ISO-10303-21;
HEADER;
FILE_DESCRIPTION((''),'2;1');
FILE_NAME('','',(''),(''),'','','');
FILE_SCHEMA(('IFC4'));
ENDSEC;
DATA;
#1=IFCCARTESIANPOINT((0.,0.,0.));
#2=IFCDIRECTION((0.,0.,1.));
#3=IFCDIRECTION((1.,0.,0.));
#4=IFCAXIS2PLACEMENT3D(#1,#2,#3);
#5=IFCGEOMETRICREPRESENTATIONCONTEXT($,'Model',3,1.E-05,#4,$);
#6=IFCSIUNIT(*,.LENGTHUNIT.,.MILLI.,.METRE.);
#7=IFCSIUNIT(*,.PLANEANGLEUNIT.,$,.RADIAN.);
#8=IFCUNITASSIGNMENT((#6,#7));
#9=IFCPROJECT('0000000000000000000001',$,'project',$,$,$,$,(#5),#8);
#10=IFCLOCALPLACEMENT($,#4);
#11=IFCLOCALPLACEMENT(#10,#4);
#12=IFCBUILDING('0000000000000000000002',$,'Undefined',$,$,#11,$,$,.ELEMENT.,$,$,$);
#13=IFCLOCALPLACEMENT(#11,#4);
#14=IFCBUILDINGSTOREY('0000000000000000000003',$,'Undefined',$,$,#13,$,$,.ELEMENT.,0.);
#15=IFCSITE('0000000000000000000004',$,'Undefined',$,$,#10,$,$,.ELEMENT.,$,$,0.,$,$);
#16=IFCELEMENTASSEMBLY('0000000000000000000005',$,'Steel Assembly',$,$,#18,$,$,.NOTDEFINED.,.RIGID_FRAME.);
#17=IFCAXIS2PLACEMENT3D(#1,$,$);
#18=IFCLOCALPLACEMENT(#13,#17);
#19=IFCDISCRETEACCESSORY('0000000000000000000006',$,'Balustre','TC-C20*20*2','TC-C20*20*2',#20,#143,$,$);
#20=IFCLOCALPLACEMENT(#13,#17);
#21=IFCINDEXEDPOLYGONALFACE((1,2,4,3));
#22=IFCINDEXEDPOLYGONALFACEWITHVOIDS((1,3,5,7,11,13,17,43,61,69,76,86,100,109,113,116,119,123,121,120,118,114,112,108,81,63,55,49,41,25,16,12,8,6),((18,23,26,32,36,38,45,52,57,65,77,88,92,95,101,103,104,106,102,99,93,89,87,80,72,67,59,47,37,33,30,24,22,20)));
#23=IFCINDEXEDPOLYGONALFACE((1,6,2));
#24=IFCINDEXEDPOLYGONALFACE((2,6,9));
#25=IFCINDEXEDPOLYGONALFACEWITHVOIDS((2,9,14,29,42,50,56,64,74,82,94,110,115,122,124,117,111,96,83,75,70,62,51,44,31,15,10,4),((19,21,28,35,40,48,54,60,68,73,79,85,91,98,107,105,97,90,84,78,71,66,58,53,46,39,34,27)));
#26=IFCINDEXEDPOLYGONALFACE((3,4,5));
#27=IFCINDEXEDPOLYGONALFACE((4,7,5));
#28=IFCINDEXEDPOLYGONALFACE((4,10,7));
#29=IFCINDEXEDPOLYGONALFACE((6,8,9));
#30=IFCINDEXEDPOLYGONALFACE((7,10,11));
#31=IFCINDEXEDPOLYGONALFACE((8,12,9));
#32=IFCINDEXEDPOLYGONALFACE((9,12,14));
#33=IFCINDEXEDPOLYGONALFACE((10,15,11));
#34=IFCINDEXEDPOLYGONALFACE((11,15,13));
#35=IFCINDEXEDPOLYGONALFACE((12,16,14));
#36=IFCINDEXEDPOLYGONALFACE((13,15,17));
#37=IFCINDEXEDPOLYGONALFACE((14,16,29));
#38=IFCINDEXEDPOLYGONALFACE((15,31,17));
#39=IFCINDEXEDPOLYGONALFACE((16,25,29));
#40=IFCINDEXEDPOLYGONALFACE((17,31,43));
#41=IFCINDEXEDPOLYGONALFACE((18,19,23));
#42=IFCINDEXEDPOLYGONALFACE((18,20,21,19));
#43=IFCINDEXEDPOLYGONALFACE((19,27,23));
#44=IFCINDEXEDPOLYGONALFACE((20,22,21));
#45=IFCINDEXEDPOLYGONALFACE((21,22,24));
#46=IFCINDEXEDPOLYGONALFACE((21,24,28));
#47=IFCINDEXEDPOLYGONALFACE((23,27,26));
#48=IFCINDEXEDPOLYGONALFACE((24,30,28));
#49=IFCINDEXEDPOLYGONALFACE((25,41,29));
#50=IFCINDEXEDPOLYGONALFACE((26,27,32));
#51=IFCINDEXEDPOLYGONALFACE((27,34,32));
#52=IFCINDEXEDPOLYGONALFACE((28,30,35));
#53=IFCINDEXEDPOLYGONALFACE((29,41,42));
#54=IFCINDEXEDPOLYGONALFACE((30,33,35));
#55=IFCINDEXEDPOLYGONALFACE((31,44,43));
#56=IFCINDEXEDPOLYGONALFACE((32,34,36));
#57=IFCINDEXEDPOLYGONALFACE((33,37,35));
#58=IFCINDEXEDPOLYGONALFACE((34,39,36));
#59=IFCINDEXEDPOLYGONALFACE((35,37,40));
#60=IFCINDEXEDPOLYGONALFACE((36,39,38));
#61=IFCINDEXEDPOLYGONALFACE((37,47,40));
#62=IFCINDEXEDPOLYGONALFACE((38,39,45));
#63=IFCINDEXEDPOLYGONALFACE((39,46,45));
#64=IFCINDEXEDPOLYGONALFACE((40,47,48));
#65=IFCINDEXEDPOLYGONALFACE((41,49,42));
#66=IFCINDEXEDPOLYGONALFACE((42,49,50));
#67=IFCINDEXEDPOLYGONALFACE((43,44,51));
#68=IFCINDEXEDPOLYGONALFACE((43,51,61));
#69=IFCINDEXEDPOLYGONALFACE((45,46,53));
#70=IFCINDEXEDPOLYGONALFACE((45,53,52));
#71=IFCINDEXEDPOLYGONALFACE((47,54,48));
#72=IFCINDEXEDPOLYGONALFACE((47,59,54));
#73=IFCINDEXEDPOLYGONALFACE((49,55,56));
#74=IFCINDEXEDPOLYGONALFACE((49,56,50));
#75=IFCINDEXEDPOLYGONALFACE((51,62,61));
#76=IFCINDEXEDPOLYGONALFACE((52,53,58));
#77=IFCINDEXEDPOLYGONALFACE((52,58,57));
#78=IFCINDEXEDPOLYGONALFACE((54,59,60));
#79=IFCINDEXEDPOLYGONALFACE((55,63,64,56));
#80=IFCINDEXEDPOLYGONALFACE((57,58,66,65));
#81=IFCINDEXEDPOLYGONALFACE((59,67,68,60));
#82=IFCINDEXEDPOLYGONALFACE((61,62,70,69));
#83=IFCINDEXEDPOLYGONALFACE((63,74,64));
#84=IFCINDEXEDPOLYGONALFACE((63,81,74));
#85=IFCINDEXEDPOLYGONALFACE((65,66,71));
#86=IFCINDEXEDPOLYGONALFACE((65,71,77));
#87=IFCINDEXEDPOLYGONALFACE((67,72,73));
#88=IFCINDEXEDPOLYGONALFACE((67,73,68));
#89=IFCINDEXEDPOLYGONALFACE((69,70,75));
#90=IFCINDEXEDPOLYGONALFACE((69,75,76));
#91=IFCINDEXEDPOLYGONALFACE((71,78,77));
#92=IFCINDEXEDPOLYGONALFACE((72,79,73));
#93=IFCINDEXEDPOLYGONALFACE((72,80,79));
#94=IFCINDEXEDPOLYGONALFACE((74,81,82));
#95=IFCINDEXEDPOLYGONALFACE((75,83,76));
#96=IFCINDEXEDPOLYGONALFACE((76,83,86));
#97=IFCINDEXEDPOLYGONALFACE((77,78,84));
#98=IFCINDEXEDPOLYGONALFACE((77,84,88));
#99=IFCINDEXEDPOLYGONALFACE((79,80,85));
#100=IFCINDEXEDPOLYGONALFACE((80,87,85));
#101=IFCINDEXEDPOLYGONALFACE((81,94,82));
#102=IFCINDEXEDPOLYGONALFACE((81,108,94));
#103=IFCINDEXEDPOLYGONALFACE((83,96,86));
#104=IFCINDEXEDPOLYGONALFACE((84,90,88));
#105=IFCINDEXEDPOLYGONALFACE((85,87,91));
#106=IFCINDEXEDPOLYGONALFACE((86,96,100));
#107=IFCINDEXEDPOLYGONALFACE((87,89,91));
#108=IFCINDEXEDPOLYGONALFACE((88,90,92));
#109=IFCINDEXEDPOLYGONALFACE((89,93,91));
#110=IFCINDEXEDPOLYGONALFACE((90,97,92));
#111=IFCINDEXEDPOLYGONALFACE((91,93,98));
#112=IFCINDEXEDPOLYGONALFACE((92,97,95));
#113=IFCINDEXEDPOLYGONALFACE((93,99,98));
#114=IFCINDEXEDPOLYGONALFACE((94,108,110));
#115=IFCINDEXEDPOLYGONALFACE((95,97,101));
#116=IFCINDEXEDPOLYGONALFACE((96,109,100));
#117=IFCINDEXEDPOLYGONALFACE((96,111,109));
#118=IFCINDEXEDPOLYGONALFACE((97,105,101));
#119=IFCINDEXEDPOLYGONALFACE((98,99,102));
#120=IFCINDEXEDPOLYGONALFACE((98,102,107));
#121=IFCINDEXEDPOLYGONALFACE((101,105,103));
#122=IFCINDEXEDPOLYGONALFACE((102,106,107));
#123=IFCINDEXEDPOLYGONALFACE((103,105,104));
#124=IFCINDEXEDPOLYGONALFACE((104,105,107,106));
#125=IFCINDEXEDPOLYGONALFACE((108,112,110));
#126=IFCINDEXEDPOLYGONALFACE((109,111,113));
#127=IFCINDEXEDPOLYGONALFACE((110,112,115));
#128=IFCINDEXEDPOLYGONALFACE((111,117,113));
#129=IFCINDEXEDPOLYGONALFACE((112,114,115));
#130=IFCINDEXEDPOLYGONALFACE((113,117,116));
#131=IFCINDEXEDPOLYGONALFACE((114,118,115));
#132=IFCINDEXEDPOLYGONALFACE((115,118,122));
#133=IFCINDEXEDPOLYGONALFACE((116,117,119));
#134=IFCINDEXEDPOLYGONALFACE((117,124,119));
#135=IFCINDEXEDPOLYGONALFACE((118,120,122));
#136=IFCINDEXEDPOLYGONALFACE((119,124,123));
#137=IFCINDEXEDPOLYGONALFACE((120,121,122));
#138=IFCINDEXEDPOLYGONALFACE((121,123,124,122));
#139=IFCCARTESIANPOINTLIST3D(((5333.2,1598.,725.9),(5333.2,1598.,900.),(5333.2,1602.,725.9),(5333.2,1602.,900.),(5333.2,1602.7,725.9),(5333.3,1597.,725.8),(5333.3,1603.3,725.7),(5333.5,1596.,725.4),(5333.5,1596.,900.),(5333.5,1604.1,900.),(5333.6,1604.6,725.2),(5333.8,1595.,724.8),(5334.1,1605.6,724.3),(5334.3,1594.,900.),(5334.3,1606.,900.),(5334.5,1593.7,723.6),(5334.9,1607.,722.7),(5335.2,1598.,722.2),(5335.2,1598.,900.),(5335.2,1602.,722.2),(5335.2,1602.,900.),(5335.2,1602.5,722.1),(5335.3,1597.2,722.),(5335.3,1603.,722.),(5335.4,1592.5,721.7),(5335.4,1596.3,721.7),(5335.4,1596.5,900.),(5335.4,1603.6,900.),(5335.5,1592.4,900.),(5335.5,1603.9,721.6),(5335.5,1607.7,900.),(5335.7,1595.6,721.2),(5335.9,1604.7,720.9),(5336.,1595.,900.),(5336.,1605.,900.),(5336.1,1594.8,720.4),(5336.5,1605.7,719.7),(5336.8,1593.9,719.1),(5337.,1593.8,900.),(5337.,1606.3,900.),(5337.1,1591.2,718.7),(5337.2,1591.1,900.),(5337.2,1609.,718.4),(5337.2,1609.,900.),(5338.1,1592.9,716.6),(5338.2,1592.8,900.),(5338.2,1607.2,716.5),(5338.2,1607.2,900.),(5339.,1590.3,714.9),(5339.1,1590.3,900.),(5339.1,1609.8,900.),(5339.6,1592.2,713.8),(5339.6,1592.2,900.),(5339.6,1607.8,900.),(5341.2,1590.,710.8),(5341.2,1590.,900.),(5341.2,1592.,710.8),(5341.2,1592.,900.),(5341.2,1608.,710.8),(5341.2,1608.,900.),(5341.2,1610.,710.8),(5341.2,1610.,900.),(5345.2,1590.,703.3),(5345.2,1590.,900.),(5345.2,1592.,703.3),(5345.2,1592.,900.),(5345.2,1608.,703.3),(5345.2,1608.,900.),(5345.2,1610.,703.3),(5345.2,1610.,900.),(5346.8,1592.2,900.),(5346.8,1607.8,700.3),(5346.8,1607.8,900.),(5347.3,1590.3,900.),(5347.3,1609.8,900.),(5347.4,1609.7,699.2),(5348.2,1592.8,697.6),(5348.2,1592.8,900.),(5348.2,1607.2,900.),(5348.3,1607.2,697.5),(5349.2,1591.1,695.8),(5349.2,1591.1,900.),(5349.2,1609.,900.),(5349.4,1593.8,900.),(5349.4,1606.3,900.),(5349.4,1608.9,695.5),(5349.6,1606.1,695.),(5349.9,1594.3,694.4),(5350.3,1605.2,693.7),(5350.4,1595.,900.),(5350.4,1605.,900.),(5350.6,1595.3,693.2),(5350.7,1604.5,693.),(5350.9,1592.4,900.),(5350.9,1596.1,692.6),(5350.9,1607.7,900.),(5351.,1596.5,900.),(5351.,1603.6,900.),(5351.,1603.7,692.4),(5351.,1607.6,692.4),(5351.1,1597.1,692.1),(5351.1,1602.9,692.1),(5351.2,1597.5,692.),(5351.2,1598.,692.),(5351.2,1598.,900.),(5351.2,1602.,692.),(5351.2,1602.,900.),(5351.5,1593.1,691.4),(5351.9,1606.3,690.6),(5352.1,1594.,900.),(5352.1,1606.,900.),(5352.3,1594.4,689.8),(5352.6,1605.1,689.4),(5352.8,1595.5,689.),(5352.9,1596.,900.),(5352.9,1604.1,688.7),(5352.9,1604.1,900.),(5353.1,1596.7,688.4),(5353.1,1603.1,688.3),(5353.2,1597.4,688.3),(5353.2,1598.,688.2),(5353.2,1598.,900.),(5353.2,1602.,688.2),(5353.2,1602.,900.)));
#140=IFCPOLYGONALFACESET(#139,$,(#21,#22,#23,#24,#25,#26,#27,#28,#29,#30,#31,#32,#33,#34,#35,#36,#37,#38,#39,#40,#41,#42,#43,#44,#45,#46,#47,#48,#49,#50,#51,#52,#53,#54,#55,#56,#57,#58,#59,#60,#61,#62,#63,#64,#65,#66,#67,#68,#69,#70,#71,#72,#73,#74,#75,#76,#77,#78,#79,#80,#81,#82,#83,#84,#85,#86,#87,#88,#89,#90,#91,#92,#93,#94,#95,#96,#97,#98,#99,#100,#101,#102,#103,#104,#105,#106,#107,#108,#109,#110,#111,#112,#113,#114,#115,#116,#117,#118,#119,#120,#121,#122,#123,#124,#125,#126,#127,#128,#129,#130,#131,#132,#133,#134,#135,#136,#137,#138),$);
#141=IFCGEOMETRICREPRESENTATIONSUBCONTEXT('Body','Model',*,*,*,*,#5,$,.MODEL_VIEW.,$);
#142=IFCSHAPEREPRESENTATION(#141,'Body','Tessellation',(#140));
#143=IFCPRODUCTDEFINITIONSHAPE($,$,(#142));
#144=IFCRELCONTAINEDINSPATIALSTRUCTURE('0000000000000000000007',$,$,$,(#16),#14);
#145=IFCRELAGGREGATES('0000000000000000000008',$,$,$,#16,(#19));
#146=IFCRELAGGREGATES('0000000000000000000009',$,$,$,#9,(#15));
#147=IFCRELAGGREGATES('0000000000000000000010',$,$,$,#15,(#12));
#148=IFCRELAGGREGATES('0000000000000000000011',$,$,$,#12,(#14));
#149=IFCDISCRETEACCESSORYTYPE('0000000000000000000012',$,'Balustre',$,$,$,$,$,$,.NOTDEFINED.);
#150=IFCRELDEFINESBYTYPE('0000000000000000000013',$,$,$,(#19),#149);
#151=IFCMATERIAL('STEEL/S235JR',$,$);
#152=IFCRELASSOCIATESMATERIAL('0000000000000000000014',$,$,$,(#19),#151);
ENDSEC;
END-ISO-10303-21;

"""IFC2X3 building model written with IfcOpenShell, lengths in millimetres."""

from ifc_helpers import new_model, si_unit, frame, origin_with_axes, origin_2d_with_axis, place, context, subcontext, project, spatial, hollow_rectangle, extrude, clip, halfspace, material, type_object, element, aggregate, save


model = new_model("IFC2X3")

# Units and contexts
model_context = context("Model", 3, precision=1e-05, world=origin_with_axes())
body_context = subcontext(model_context, "Body", "Model", "MODEL_VIEW")
ifc_project = project(units=[si_unit("LENGTHUNIT", "METRE", prefix="MILLI"), si_unit("PLANEANGLEUNIT", "RADIAN")], contexts=[model_context])

# Site, building, storey
site_placement = place(None, origin_with_axes())
site = spatial("IfcSite", under=ifc_project, at=site_placement, Name="Undefined", CompositionType="ELEMENT", RefElevation=0.0)
building_placement = place(site_placement, origin_with_axes())
building = spatial("IfcBuilding", under=site, at=building_placement, Name="Undefined", CompositionType="ELEMENT")
storey_placement = place(building_placement, origin_with_axes())
storey = spatial("IfcBuildingStorey", under=building, at=storey_placement, Name="Undefined", CompositionType="ELEMENT", Elevation=0.0)

# Shared definitions
ifc_material = material(Name="STEEL/S235JR")

# Shared definitions
discrete_accessory_type_1 = type_object("IfcDiscreteAccessoryType", Name="Balustre")

# Element assembly, discrete accessory
assembly_1_placement = place(storey_placement, origin_with_axes())
assembly_1 = element("IfcElementAssembly", 1, at=assembly_1_placement, inside=storey, Name="Steel Assembly", AssemblyPlace="NOTDEFINED", PredefinedType="RIGID_FRAME")
discrete_accessory_1_placement = place(assembly_1_placement, frame((5343.2, 1600.0, 900.0), z_axis=(0.0, 1.0, 0.0), x_axis=(0.0, 0.0, -1.0)))
discrete_accessory_1 = element("IfcDiscreteAccessory", 2, at=discrete_accessory_1_placement, type_object=discrete_accessory_type_1, material=ifc_material, Name="Balustre", Description="TC-C20*20*2", ObjectType="TC-C20*20*2", context=body_context, shape_type="Clipping", body=[
    clip(extrude(hollow_rectangle(XDim=20.0, YDim=20.0, WallThickness=2.0, InnerFilletRadius=6.0, OuterFilletRadius=8.0, at=origin_2d_with_axis()), frame((212.0, 0.0, 0.0), z_axis=(-1.0, 0.0, 0.0), x_axis=(0.0, -1.0, 0.0)), (0.0, 0.0, 1.0), 212.0), halfspace(frame((150.3, 22.6, 0.0), z_axis=(-0.46842, -0.883506, 0.000005), x_axis=(0.0, 0.000005, 1.0)), True)),
])

aggregate(assembly_1, [discrete_accessory_1])

save(model, "model.ifc")
